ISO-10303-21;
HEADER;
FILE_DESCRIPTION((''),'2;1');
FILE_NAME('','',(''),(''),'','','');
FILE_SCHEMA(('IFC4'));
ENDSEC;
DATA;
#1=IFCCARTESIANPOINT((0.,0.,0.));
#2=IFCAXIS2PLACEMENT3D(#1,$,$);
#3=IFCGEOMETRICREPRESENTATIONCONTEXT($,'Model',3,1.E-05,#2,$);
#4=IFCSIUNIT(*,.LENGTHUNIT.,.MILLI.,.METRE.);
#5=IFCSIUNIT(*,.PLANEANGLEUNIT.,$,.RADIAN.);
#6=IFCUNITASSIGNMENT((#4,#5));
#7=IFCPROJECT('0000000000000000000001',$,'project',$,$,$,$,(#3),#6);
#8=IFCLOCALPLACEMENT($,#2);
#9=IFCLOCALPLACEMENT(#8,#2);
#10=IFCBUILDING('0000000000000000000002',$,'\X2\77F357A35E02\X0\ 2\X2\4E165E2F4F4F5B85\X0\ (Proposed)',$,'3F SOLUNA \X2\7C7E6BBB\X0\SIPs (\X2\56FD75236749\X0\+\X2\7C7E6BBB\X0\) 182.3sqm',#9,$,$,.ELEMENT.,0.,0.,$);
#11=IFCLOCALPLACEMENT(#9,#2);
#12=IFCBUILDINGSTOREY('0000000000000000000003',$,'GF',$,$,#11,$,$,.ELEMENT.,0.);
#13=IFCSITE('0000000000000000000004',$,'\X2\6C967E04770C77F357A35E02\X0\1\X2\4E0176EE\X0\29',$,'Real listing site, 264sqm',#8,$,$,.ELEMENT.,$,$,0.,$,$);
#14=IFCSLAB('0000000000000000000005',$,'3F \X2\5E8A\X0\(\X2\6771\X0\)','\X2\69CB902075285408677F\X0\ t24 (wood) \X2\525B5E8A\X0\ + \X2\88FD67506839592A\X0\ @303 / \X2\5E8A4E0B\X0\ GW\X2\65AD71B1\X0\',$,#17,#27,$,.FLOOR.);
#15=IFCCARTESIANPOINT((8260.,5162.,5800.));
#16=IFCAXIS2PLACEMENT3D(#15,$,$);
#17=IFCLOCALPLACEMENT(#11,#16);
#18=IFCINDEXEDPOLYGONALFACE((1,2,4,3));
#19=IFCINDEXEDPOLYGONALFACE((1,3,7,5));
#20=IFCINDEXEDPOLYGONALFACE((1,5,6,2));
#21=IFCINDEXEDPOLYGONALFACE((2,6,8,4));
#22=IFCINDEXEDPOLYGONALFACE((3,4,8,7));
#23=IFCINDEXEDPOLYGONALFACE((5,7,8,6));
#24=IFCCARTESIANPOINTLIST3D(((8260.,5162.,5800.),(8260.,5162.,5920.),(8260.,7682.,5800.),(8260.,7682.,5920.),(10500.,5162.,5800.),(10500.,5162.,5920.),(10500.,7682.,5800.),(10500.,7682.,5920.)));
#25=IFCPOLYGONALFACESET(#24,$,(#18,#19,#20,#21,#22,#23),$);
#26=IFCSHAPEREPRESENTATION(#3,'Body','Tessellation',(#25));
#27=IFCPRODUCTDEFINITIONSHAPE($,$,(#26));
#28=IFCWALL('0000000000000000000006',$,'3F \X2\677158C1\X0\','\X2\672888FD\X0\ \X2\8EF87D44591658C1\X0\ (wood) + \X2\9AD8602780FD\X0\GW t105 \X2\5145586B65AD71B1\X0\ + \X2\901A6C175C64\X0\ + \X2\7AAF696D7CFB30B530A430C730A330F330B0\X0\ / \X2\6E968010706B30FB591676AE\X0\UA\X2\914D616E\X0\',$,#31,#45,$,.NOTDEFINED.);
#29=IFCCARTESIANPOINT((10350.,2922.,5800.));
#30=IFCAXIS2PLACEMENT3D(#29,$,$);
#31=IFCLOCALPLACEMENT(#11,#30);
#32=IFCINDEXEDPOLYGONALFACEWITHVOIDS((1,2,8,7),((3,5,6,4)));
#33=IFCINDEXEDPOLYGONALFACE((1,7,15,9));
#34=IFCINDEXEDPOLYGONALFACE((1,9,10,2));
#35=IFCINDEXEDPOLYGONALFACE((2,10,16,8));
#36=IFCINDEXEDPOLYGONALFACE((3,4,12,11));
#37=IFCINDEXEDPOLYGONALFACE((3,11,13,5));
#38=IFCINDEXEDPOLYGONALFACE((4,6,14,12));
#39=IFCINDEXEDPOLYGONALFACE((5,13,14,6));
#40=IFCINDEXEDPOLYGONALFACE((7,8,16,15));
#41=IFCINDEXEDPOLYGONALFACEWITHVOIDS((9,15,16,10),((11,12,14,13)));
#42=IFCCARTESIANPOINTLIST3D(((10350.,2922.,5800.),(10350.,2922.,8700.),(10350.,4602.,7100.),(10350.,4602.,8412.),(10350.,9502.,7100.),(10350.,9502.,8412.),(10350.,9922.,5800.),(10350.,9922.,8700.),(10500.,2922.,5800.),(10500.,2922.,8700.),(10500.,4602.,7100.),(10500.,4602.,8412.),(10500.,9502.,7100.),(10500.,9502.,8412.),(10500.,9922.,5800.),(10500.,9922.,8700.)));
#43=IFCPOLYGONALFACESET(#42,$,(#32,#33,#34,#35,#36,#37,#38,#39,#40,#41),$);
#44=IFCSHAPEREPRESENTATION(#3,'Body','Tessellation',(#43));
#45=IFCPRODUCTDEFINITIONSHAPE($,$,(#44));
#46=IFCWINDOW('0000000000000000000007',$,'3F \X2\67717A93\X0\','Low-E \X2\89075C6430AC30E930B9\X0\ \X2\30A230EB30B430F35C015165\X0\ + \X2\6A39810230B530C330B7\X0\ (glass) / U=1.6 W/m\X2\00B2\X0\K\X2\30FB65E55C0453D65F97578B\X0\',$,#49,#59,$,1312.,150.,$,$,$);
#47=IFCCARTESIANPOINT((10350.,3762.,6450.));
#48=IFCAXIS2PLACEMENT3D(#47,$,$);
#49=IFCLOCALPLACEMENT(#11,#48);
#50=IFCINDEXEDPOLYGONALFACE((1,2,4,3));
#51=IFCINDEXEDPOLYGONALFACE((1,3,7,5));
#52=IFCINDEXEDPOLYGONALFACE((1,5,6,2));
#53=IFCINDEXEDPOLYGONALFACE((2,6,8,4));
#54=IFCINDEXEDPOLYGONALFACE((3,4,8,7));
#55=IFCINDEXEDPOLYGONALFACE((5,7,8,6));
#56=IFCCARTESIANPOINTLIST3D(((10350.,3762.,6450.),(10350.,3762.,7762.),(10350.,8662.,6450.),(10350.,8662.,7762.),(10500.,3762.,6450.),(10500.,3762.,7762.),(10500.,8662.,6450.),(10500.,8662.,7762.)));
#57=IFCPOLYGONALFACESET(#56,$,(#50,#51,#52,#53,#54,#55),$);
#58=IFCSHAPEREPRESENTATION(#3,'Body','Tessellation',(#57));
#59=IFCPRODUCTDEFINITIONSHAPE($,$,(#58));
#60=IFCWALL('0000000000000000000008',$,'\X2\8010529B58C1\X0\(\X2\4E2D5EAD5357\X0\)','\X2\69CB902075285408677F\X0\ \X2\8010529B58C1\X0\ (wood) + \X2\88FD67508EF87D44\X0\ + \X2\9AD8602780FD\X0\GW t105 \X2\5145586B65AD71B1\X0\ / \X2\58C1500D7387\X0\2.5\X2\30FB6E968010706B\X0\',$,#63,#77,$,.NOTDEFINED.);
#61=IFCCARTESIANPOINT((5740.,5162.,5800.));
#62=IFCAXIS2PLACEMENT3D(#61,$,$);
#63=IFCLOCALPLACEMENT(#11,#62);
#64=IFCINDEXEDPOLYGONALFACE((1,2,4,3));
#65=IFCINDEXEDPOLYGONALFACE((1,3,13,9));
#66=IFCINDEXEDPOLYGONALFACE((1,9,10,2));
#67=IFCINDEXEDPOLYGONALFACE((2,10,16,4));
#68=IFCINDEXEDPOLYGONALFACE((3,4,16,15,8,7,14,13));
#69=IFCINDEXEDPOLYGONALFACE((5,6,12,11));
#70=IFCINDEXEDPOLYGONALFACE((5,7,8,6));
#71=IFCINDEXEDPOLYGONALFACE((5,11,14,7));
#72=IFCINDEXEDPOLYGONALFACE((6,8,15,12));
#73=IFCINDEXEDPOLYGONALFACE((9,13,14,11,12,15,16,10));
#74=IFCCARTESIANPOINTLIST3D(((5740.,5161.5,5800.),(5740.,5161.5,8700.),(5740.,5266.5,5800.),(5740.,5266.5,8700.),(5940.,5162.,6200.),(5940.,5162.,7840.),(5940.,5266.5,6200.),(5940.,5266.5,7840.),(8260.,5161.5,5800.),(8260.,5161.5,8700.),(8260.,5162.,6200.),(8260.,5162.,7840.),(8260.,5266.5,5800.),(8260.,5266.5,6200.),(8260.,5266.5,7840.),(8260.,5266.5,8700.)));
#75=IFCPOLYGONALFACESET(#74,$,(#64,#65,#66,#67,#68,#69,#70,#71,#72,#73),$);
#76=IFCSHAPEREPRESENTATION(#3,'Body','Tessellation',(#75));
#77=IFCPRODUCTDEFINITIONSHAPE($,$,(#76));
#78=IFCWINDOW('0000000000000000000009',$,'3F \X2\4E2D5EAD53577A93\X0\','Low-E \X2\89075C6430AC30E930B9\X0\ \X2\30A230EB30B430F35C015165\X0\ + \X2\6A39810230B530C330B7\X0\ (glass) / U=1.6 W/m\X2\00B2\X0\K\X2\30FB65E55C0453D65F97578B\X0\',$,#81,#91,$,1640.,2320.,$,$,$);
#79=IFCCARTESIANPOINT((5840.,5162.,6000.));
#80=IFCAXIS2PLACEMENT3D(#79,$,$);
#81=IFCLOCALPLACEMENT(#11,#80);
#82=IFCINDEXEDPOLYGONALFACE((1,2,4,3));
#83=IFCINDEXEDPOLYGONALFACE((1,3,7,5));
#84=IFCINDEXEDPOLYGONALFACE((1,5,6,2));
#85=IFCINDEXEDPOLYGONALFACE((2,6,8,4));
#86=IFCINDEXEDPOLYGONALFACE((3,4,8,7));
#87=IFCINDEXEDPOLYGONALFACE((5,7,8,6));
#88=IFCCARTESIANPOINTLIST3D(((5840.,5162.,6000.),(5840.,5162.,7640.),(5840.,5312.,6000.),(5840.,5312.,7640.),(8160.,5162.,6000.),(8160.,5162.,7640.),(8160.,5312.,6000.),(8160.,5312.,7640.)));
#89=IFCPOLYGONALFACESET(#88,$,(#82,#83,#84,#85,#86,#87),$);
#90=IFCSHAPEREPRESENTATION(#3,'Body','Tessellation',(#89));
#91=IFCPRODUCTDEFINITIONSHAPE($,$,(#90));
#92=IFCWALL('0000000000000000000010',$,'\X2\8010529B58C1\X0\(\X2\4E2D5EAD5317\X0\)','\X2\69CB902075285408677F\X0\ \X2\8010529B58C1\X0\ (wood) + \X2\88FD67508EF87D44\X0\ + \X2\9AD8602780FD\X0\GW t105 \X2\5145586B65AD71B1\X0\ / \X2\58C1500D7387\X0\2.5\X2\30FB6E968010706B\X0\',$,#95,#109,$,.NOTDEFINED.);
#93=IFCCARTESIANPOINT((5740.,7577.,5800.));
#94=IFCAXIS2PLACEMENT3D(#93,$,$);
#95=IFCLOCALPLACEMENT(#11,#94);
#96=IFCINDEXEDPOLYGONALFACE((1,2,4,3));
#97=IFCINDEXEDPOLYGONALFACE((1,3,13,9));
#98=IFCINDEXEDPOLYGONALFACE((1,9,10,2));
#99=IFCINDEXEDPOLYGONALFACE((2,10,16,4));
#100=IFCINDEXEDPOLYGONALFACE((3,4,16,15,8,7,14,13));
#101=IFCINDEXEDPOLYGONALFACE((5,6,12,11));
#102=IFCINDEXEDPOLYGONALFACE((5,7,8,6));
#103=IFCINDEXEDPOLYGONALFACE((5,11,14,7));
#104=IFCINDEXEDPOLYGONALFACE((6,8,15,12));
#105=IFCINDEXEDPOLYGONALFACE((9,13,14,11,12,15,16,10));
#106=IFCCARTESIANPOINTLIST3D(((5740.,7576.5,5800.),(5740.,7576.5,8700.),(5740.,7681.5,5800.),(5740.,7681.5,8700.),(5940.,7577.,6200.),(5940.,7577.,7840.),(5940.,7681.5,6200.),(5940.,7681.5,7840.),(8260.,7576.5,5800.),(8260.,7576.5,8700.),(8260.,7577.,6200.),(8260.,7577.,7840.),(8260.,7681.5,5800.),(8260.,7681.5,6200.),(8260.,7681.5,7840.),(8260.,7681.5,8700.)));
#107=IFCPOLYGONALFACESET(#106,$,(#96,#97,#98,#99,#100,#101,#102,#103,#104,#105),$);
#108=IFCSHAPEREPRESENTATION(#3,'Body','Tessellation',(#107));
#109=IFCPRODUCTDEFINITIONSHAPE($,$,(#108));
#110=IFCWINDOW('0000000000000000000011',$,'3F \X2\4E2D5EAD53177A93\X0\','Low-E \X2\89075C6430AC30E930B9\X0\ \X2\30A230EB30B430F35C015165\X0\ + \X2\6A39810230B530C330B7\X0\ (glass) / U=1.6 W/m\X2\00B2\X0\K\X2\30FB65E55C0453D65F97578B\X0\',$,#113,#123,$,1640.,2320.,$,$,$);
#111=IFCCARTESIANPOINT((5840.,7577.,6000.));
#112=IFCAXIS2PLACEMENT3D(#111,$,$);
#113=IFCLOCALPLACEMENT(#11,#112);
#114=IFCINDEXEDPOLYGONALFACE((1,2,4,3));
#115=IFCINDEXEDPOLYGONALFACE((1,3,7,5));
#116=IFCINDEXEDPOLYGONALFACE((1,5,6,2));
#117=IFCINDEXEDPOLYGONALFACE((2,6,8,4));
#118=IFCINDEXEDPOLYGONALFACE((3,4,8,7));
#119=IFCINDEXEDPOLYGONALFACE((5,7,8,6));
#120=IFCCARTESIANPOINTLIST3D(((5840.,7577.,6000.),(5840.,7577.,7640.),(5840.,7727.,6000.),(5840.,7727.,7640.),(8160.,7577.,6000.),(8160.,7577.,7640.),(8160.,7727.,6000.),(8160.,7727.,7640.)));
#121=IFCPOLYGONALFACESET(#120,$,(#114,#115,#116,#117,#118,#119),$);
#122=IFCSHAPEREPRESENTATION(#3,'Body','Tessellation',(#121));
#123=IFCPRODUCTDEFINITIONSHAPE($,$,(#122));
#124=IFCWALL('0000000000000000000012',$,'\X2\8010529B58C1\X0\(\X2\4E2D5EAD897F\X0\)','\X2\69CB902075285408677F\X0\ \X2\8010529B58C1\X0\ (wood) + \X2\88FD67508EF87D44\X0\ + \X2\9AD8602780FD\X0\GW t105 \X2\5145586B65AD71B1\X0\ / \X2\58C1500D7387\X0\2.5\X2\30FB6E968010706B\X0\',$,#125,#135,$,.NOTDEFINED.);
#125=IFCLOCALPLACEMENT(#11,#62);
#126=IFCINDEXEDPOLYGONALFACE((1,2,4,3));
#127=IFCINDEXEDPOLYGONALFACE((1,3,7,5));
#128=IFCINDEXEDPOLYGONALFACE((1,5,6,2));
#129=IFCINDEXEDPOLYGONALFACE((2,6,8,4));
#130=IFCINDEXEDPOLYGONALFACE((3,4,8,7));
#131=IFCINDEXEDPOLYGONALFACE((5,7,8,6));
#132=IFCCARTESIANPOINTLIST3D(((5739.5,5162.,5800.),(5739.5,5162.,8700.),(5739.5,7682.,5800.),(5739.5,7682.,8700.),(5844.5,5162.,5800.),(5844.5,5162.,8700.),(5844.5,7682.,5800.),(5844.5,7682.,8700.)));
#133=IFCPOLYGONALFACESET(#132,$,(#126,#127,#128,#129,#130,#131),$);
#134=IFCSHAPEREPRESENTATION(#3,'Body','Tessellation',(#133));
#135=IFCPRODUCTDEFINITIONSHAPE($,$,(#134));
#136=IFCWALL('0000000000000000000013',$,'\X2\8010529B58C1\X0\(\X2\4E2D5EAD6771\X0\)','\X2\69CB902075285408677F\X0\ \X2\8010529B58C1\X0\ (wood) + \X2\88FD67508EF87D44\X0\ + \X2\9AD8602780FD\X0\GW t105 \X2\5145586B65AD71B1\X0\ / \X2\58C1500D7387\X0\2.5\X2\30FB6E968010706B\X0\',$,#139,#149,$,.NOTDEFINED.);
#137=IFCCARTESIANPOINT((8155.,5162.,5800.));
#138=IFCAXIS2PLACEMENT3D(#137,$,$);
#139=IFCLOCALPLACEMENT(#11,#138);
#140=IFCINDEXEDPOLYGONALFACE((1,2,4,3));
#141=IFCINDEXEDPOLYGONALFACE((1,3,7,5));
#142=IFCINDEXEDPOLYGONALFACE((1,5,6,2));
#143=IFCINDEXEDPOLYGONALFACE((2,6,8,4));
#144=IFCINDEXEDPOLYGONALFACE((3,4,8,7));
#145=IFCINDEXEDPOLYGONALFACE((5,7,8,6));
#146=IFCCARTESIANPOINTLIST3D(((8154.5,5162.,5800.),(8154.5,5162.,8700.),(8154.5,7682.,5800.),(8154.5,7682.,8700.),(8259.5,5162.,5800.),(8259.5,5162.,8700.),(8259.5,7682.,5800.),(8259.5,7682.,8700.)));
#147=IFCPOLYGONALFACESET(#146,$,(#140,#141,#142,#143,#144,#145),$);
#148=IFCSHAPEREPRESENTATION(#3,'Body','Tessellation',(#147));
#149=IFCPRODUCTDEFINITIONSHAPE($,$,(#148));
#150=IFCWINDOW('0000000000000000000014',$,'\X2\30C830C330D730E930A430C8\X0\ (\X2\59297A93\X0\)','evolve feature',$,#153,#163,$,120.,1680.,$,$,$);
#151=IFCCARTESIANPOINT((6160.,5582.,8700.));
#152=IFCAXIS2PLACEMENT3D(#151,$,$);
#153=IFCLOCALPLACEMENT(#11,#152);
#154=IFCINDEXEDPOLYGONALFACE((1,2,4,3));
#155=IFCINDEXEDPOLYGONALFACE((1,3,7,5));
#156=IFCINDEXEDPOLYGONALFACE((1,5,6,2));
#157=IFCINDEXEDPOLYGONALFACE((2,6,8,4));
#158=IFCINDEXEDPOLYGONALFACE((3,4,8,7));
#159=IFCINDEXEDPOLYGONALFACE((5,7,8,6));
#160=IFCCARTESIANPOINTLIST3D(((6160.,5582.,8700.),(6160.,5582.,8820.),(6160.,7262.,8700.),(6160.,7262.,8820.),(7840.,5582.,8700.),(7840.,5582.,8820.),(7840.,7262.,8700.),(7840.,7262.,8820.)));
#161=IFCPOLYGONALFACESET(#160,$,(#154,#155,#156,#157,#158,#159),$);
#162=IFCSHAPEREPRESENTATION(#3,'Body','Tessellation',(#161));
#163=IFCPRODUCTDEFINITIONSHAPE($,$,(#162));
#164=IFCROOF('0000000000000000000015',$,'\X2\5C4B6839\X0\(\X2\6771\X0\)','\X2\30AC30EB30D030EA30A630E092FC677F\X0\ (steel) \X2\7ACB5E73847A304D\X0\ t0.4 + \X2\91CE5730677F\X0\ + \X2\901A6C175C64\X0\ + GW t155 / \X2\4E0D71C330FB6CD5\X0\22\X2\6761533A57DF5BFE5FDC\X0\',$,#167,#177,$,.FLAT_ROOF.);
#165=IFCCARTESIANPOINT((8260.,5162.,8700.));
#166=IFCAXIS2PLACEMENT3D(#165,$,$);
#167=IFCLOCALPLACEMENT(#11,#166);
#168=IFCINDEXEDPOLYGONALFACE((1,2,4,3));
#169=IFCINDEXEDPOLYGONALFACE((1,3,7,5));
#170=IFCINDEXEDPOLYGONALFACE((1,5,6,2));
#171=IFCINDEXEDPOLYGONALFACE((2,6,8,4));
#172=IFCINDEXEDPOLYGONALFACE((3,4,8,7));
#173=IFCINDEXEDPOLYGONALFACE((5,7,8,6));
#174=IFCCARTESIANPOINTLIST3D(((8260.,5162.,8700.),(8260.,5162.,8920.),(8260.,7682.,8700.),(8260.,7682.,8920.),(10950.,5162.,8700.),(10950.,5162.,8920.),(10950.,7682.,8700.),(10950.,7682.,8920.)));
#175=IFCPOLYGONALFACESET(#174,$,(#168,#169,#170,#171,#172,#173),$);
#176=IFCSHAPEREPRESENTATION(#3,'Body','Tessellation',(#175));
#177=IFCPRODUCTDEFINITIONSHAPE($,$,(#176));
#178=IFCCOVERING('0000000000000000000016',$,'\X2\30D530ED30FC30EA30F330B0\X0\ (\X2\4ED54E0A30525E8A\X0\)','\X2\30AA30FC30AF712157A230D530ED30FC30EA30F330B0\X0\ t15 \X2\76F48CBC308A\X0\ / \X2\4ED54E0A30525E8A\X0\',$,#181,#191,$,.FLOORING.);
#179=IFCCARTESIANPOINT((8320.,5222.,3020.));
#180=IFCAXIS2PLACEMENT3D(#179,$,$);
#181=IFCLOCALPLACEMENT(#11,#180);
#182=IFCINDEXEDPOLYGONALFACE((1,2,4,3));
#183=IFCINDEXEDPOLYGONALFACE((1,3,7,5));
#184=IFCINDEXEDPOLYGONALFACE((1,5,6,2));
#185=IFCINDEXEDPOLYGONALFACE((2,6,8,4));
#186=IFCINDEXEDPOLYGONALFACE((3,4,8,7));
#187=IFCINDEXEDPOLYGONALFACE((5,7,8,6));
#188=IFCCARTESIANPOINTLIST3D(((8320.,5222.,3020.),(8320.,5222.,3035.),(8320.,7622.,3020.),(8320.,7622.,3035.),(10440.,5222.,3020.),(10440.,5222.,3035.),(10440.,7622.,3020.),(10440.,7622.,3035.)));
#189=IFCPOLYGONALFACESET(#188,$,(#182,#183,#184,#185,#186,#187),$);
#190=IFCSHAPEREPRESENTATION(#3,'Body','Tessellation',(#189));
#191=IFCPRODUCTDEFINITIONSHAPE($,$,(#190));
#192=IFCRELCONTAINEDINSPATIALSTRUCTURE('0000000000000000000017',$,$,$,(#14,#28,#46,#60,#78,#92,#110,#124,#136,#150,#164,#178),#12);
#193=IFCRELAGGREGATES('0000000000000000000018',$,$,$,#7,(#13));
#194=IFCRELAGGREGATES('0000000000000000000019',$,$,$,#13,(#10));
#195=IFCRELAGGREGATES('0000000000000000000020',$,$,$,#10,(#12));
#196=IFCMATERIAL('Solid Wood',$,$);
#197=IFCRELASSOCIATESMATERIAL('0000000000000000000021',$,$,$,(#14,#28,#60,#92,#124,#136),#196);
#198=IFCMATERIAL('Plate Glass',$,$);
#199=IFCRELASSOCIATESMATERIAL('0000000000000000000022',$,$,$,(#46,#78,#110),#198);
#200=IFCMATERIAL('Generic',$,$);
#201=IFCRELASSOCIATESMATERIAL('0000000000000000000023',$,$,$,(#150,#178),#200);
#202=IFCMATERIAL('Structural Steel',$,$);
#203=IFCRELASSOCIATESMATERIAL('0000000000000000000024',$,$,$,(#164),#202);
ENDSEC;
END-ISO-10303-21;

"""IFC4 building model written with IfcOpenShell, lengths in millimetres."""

from ifc_helpers import new_model, si_unit, frame, frame_2d, origin, place, context, project, spatial, rectangle, extrude, material, element, fill, save


model = new_model("IFC4")

# Units and contexts
model_context = context("Model", 3, precision=1e-05, world=origin())
ifc_project = project(units=[si_unit("LENGTHUNIT", "METRE", prefix="MILLI"), si_unit("PLANEANGLEUNIT", "RADIAN")], contexts=[model_context])

# Site, building, storey
site_placement = place(None, origin())
site = spatial("IfcSite", under=ifc_project, at=site_placement, Name="沖縄県石垣市1丁目29", ObjectType="Real listing site, 264sqm", CompositionType="ELEMENT", RefElevation=0.0)
building_placement = place(site_placement, origin())
building = spatial("IfcBuilding", under=site, at=building_placement, Name="石垣市 2世帯住宅 (Proposed)", ObjectType="3F SOLUNA 籾殻SIPs (国産杉+籾殻) 182.3sqm", CompositionType="ELEMENT", ElevationOfRefHeight=0.0, ElevationOfTerrain=0.0)
storey_placement = place(building_placement, origin())
storey = spatial("IfcBuildingStorey", under=building, at=storey_placement, Name="GF", CompositionType="ELEMENT", Elevation=0.0)

# Slab
ifc_material_1 = material(Name="Solid Wood")
slab_placement = place(storey_placement, frame((8260.0, 5162.0, 5800.0)))
element("IfcSlab", 1, at=slab_placement, inside=storey, material=ifc_material_1, Name="3F 床(東)", Description="構造用合板 t24 (wood) 剛床 + 製材根太 @303 / 床下 GW断熱", PredefinedType="FLOOR", context=model_context, shape_type="SweptSolid", body=[
    extrude(rectangle(XDim=2240.0, YDim=2520.0, at=frame_2d((1120.0, 1260.0))), frame((8260.0, 5162.0, 5800.0)), (0.0, 0.0, 1.0), 120.0),
])

# Walls, openings, windows
wall_1_placement = place(storey_placement, frame((10350.0, 2922.0, 5800.0)))
wall_1 = element("IfcWall", 2, at=wall_1_placement, inside=storey, material=ifc_material_1, Name="3F 東壁", Description="木製 軸組外壁 (wood) + 高性能GW t105 充填断熱 + 通気層 + 窯業系サイディング / 準耐火・外皮UA配慮", PredefinedType="NOTDEFINED", context=model_context, shape_type="SweptSolid", body=[
    extrude(rectangle(XDim=150.0, YDim=7000.0, at=frame_2d((75.0, 3500.0))), frame((10350.0, 2922.0, 5800.0)), (0.0, 0.0, 1.0), 2900.0),
])
opening_1_placement = place(storey_placement, frame((10350.0, 3762.0, 6450.0)))
opening_1 = element("IfcOpeningElement", 3, at=opening_1_placement, cuts=wall_1, PredefinedType="NOTDEFINED", context=model_context, shape_type="SweptSolid", body=[
    extrude(rectangle(XDim=150.0, YDim=4900.0, at=frame_2d((75.0, 2450.0))), frame((10350.0, 3762.0, 6450.0)), (0.0, 0.0, 1.0), 1312.0),
])
ifc_material_2 = material(Name="Plate Glass")
window_1_placement = place(storey_placement, frame((10350.0, 3762.0, 6450.0)))
window_1 = element("IfcWindow", 4, at=window_1_placement, inside=storey, material=ifc_material_2, Name="3F 東窓", Description="Low-E 複層ガラス アルゴン封入 + 樹脂サッシ (glass) / U=1.6 W/m²K・日射取得型", OverallHeight=1312.0, OverallWidth=150.0, context=model_context, shape_type="SweptSolid", body=[
    extrude(rectangle(XDim=150.0, YDim=4900.0, at=frame_2d((75.0, 2450.0))), frame((10350.0, 3762.0, 6450.0)), (0.0, 0.0, 1.0), 1312.0),
])
fill(opening_1, window_1)
wall_2_placement = place(storey_placement, frame((5740.0, 5162.0, 5800.0)))
wall_2 = element("IfcWall", 5, at=wall_2_placement, inside=storey, material=ifc_material_1, Name="耐力壁(中庭南)", Description="構造用合板 耐力壁 (wood) + 製材軸組 + 高性能GW t105 充填断熱 / 壁倍率2.5・準耐火", PredefinedType="NOTDEFINED", context=model_context, shape_type="SweptSolid", body=[
    extrude(rectangle(XDim=2520.0, YDim=105.0, at=frame_2d((1260.0, 52.0))), frame((5740.0, 5162.0, 5800.0)), (0.0, 0.0, 1.0), 2900.0),
])
opening_2_placement = place(storey_placement, frame((5840.0, 5162.0, 6000.0)))
opening_2 = element("IfcOpeningElement", 6, at=opening_2_placement, cuts=wall_2, PredefinedType="NOTDEFINED", context=model_context, shape_type="SweptSolid", body=[
    extrude(rectangle(XDim=2320.0, YDim=150.0, at=frame_2d((1160.0, 75.0))), frame((5840.0, 5162.0, 6000.0)), (0.0, 0.0, 1.0), 1640.0),
])
window_2_placement = place(storey_placement, frame((5840.0, 5162.0, 6000.0)))
window_2 = element("IfcWindow", 7, at=window_2_placement, inside=storey, material=ifc_material_2, Name="3F 中庭南窓", Description="Low-E 複層ガラス アルゴン封入 + 樹脂サッシ (glass) / U=1.6 W/m²K・日射取得型", OverallHeight=1640.0, OverallWidth=2320.0, context=model_context, shape_type="SweptSolid", body=[
    extrude(rectangle(XDim=2320.0, YDim=150.0, at=frame_2d((1160.0, 75.0))), frame((5840.0, 5162.0, 6000.0)), (0.0, 0.0, 1.0), 1640.0),
])
fill(opening_2, window_2)
wall_3_placement = place(storey_placement, frame((5740.0, 7577.0, 5800.0)))
wall_3 = element("IfcWall", 8, at=wall_3_placement, inside=storey, material=ifc_material_1, Name="耐力壁(中庭北)", Description="構造用合板 耐力壁 (wood) + 製材軸組 + 高性能GW t105 充填断熱 / 壁倍率2.5・準耐火", PredefinedType="NOTDEFINED", context=model_context, shape_type="SweptSolid", body=[
    extrude(rectangle(XDim=2520.0, YDim=105.0, at=frame_2d((1260.0, 52.0))), frame((5740.0, 7577.0, 5800.0)), (0.0, 0.0, 1.0), 2900.0),
])
opening_3_placement = place(storey_placement, frame((5840.0, 7577.0, 6000.0)))
opening_3 = element("IfcOpeningElement", 9, at=opening_3_placement, cuts=wall_3, PredefinedType="NOTDEFINED", context=model_context, shape_type="SweptSolid", body=[
    extrude(rectangle(XDim=2320.0, YDim=150.0, at=frame_2d((1160.0, 75.0))), frame((5840.0, 7577.0, 6000.0)), (0.0, 0.0, 1.0), 1640.0),
])
window_3_placement = place(storey_placement, frame((5840.0, 7577.0, 6000.0)))
window_3 = element("IfcWindow", 10, at=window_3_placement, inside=storey, material=ifc_material_2, Name="3F 中庭北窓", Description="Low-E 複層ガラス アルゴン封入 + 樹脂サッシ (glass) / U=1.6 W/m²K・日射取得型", OverallHeight=1640.0, OverallWidth=2320.0, context=model_context, shape_type="SweptSolid", body=[
    extrude(rectangle(XDim=2320.0, YDim=150.0, at=frame_2d((1160.0, 75.0))), frame((5840.0, 7577.0, 6000.0)), (0.0, 0.0, 1.0), 1640.0),
])
fill(opening_3, window_3)

# Walls
wall_4_placement = place(storey_placement, frame((5740.0, 5162.0, 5800.0)))
element("IfcWall", 11, at=wall_4_placement, inside=storey, material=ifc_material_1, Name="耐力壁(中庭西)", Description="構造用合板 耐力壁 (wood) + 製材軸組 + 高性能GW t105 充填断熱 / 壁倍率2.5・準耐火", PredefinedType="NOTDEFINED", context=model_context, shape_type="SweptSolid", body=[
    extrude(rectangle(XDim=105.0, YDim=2520.0, at=frame_2d((52.0, 1260.0))), frame((5740.0, 5162.0, 5800.0)), (0.0, 0.0, 1.0), 2900.0),
])
wall_5_placement = place(storey_placement, frame((8155.0, 5162.0, 5800.0)))
element("IfcWall", 12, at=wall_5_placement, inside=storey, material=ifc_material_1, Name="耐力壁(中庭東)", Description="構造用合板 耐力壁 (wood) + 製材軸組 + 高性能GW t105 充填断熱 / 壁倍率2.5・準耐火", PredefinedType="NOTDEFINED", context=model_context, shape_type="SweptSolid", body=[
    extrude(rectangle(XDim=105.0, YDim=2520.0, at=frame_2d((52.0, 1260.0))), frame((8155.0, 5162.0, 5800.0)), (0.0, 0.0, 1.0), 2900.0),
])

# Window
ifc_material_3 = material(Name="Generic")
window_4_placement = place(storey_placement, frame((6160.0, 5582.0, 8700.0)))
element("IfcWindow", 13, at=window_4_placement, inside=storey, material=ifc_material_3, Name="トップライト (天窓)", Description="evolve feature", OverallHeight=120.0, OverallWidth=1680.0, context=model_context, shape_type="SweptSolid", body=[
    extrude(rectangle(XDim=1680.0, YDim=1680.0, at=frame_2d((840.0, 840.0))), frame((6160.0, 5582.0, 8700.0)), (0.0, 0.0, 1.0), 120.0),
])

# Roof
ifc_material_4 = material(Name="Structural Steel")
for number, where, name in (
    (14, (8260.0, 5162.0, 8700.0), "屋根(東)"),
):
    element("IfcRoof", number, at=place(storey_placement, frame(where)), inside=storey, material=ifc_material_4, Name=name, Description="ガルバリウム鋼板 (steel) 立平葺き t0.4 + 野地板 + 通気層 + GW t155 / 不燃・法22条区域対応", PredefinedType="FLAT_ROOF", context=model_context, shape_type="SweptSolid", body=[
        extrude(rectangle(XDim=2690.0, YDim=2520.0, at=frame_2d((1345.0, 1260.0))), frame((8260.0, 5162.0, 8700.0)), (0.0, 0.0, 1.0), 220.0),
    ])

# Covering
covering_1_placement = place(storey_placement, frame((8320.0, 5222.0, 3020.0)))
element("IfcCovering", 15, at=covering_1_placement, inside=storey, material=ifc_material_3, Name="フローリング (仕上げ床)", Description="オーク無垢フローリング t15 直貼り / 仕上げ床", PredefinedType="FLOORING", context=model_context, shape_type="SweptSolid", body=[
    extrude(rectangle(XDim=2120.0, YDim=2400.0, at=frame_2d((1060.0, 1200.0))), frame((8320.0, 5222.0, 3020.0)), (0.0, 0.0, 1.0), 15.0),
])

save(model, "model.ifc")
